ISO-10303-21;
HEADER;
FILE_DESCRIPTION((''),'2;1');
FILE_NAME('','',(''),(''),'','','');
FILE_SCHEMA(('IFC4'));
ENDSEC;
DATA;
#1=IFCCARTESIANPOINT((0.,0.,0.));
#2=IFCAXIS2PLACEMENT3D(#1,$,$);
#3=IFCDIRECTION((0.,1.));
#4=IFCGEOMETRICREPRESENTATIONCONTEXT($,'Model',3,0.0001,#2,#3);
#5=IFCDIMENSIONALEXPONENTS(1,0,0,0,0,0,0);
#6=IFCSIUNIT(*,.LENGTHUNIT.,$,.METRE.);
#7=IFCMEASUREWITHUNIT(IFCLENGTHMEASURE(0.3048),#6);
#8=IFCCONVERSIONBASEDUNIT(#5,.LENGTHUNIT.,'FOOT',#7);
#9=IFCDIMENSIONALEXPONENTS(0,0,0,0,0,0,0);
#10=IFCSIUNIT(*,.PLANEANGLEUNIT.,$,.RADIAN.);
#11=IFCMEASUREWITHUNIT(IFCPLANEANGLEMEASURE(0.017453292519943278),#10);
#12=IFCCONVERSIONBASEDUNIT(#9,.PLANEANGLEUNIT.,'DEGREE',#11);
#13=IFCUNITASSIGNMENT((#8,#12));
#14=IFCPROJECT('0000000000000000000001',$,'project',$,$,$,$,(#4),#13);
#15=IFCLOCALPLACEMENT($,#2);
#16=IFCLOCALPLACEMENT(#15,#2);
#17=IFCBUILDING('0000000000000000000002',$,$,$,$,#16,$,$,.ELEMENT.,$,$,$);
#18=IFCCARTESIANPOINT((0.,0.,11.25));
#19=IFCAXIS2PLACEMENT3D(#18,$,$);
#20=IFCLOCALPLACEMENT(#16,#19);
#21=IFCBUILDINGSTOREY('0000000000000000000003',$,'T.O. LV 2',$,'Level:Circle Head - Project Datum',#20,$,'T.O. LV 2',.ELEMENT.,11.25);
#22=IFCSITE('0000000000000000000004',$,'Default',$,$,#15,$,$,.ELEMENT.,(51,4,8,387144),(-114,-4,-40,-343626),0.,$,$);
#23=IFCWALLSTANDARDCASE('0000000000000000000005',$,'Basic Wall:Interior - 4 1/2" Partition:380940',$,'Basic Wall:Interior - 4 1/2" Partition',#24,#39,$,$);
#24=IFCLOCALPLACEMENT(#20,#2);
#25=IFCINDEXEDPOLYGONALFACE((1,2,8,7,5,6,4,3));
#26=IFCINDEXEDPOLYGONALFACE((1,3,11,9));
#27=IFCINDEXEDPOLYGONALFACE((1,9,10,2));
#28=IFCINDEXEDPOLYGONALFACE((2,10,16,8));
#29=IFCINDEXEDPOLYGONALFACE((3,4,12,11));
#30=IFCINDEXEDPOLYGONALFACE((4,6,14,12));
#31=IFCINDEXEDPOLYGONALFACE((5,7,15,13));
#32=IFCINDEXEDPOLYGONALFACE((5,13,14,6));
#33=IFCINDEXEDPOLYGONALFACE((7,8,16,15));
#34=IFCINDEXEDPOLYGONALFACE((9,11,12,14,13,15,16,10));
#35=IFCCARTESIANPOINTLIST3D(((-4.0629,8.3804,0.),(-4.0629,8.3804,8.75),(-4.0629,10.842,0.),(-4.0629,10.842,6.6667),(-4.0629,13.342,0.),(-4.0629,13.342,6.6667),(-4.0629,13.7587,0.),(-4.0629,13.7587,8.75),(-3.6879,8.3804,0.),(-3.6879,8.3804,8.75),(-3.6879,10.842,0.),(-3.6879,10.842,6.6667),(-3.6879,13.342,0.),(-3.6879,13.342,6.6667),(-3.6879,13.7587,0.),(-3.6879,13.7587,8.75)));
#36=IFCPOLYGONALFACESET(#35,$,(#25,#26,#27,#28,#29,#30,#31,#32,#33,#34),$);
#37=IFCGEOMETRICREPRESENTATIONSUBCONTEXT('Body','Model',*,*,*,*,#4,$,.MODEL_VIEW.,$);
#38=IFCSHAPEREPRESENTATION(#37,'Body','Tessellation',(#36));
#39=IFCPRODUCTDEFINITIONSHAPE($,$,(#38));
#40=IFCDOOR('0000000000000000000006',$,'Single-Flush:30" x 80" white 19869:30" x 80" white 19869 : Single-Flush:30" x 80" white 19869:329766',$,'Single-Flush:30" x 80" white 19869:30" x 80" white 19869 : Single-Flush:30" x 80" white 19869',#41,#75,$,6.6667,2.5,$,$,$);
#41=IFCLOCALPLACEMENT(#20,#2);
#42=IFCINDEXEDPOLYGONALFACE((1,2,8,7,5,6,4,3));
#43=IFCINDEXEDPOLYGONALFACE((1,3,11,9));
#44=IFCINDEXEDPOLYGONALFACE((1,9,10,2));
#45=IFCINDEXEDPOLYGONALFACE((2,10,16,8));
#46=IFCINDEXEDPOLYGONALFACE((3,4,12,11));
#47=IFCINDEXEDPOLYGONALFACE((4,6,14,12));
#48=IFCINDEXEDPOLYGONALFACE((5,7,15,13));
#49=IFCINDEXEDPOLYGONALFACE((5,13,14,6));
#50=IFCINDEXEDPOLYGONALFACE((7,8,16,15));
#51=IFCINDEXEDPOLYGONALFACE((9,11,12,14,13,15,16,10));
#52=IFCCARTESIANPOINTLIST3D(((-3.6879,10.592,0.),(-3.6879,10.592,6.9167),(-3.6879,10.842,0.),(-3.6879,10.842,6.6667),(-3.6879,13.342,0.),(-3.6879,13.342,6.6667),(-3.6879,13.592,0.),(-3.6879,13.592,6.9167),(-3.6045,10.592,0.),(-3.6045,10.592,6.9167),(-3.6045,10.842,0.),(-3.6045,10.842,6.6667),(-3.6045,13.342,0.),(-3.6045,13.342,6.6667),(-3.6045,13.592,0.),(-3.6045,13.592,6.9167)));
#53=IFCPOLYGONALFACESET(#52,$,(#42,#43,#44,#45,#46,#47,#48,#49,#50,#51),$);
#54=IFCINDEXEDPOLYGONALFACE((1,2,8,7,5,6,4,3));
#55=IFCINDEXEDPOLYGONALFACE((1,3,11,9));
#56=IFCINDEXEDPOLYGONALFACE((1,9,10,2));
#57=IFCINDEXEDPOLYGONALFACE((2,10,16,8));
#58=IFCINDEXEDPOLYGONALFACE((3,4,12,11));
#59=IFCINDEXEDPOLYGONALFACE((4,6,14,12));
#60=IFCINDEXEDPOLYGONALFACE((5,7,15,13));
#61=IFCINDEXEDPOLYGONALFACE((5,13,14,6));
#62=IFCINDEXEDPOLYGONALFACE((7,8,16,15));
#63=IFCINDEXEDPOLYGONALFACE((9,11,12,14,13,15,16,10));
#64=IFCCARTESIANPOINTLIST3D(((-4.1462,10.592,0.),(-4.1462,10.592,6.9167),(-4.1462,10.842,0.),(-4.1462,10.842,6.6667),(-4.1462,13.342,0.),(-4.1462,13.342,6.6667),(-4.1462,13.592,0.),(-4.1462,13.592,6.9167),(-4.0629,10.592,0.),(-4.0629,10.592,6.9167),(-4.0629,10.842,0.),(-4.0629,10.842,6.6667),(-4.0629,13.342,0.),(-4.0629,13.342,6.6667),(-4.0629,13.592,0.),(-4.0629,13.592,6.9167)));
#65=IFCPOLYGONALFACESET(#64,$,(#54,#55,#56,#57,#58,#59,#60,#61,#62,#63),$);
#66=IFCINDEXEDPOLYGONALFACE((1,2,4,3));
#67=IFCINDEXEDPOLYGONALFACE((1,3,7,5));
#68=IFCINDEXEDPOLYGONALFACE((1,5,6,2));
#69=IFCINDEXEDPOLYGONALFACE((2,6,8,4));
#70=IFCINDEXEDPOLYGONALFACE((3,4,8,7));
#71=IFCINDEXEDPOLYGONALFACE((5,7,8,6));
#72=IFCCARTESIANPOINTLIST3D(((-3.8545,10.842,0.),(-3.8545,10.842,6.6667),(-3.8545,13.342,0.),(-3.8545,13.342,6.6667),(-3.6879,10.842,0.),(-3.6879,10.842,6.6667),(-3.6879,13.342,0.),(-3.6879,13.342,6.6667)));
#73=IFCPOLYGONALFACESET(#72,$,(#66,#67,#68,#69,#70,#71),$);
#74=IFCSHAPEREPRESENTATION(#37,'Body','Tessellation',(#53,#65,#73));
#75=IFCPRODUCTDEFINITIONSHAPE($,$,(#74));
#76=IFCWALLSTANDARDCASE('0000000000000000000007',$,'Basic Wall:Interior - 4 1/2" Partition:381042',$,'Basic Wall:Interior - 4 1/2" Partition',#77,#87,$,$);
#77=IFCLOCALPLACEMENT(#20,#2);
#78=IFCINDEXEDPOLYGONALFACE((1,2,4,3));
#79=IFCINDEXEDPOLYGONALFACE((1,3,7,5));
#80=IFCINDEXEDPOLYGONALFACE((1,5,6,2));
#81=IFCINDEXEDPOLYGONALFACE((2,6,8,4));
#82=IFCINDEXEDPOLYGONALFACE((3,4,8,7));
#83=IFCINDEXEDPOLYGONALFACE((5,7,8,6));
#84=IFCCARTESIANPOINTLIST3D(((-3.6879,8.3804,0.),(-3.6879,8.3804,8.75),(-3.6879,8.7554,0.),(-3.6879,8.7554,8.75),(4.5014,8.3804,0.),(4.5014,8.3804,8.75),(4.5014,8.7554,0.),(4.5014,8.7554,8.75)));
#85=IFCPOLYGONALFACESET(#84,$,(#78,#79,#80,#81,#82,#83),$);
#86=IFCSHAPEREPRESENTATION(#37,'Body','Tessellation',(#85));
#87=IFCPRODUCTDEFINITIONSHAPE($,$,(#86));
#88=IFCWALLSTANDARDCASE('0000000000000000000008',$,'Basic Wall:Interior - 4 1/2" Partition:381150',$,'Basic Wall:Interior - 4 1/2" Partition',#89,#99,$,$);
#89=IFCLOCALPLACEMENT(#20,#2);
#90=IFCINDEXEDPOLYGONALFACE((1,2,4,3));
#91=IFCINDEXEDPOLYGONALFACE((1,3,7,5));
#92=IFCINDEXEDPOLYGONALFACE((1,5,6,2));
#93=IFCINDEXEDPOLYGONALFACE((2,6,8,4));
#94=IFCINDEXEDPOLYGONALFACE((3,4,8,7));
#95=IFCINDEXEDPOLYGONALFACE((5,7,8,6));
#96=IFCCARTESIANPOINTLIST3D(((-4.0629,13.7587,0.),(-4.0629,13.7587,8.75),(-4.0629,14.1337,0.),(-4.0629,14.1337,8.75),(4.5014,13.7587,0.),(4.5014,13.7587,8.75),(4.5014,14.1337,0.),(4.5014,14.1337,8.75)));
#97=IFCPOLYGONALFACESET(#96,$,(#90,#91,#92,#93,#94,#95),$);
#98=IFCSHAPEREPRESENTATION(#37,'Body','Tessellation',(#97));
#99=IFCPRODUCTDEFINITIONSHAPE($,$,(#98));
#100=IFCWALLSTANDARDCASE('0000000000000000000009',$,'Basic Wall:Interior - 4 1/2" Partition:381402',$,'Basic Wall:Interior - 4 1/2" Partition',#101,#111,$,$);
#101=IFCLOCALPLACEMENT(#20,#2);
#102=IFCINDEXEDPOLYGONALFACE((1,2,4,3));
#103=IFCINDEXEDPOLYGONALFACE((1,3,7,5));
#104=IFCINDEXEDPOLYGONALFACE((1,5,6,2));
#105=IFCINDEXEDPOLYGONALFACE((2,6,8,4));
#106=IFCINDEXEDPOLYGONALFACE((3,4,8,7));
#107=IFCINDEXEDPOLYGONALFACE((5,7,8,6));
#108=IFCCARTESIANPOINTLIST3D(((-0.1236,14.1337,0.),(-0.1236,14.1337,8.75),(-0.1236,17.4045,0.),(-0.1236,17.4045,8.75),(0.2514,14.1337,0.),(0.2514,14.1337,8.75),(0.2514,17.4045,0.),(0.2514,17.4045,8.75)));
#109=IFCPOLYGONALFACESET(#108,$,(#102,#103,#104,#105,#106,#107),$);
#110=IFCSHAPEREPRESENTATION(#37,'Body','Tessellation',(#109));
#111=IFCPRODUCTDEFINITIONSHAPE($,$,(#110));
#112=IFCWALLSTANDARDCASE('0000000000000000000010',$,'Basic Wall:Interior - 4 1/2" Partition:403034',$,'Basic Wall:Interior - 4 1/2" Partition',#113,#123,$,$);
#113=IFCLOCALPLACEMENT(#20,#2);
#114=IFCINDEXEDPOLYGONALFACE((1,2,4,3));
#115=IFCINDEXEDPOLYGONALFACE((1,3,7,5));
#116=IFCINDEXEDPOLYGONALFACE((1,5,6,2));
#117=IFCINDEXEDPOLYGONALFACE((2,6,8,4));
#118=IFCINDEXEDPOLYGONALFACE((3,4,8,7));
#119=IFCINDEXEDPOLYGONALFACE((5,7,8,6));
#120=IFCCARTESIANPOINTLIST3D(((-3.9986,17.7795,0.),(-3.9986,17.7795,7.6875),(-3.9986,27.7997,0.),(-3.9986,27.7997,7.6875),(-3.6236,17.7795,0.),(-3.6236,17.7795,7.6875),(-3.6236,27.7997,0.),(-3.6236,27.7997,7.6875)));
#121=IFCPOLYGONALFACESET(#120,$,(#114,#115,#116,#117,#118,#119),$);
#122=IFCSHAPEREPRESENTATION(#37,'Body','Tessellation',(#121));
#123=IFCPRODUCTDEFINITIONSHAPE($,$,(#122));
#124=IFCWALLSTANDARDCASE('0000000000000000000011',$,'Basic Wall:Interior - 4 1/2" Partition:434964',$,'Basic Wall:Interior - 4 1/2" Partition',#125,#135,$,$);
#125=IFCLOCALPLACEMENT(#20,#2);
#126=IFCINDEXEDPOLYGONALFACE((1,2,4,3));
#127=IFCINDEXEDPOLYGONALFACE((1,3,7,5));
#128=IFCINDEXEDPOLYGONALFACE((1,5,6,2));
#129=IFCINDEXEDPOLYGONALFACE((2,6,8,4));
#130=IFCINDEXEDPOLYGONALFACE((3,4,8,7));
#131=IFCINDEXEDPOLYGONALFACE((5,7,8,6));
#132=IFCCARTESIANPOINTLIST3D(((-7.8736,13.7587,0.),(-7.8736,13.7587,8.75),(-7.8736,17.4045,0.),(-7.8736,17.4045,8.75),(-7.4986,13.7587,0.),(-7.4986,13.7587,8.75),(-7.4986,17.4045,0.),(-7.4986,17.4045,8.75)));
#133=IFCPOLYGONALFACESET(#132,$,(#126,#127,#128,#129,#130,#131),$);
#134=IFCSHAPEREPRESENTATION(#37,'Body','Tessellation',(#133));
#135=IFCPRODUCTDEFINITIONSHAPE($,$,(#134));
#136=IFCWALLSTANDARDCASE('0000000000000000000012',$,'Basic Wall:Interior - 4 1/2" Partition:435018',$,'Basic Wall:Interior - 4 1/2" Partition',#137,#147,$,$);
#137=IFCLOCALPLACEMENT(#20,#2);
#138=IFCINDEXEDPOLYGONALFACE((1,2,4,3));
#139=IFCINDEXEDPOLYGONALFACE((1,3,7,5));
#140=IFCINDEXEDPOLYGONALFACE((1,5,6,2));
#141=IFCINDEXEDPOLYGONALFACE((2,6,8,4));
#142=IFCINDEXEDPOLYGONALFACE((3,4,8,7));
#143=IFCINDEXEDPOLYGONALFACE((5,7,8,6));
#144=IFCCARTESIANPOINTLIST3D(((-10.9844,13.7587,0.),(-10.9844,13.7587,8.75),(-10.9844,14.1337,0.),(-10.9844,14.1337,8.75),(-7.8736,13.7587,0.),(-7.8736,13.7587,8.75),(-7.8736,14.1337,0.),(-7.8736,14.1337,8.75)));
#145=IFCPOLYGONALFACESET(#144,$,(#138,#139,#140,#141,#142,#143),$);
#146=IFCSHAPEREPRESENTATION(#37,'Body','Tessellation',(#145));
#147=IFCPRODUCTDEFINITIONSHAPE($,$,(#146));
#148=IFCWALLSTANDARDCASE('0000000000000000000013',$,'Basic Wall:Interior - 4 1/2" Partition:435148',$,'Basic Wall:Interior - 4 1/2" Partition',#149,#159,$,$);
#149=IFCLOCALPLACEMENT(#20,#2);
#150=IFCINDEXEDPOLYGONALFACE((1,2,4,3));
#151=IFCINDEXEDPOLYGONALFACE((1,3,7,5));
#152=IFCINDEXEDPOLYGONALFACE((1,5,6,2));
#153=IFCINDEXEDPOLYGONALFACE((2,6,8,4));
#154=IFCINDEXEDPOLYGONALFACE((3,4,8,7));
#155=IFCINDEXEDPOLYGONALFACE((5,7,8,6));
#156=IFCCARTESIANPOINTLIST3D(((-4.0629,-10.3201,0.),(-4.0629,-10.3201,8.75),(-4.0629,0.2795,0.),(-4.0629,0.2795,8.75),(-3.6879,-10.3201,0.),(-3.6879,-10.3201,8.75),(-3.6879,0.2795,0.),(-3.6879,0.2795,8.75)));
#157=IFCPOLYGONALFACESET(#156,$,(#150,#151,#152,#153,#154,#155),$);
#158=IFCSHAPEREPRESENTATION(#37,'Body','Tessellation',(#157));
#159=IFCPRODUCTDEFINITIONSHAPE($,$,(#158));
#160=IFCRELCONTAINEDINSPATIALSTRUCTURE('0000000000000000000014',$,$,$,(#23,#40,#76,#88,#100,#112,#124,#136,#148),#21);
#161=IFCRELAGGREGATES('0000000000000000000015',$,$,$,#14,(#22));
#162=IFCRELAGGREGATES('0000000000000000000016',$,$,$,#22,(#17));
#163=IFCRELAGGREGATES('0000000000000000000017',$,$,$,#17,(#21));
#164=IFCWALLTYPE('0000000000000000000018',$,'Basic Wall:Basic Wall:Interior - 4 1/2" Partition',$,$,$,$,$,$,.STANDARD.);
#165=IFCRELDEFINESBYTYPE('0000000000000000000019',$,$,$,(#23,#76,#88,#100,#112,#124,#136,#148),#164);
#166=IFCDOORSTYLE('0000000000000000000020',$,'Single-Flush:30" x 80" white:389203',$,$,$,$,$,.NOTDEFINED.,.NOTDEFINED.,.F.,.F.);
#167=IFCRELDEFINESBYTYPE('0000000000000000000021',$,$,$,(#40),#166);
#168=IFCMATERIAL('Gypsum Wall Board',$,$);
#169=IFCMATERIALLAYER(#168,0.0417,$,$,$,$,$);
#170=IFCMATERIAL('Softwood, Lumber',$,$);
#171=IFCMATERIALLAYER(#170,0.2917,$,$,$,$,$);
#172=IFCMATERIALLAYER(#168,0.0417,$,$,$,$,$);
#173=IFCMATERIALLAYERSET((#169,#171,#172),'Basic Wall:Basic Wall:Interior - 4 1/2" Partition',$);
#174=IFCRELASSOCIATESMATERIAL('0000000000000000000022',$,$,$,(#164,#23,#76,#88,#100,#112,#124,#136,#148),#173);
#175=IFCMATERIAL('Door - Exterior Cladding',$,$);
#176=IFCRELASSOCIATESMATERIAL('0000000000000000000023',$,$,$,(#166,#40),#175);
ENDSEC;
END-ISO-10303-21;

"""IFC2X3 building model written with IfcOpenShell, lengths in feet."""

from ifc_helpers import new_model, entity, si_unit, converted_unit, direction, frame, frame_2d, origin, place, context, subcontext, project, spatial, polyline, rectangle, outline, extrude, source, transform, mapped, material, layer, layer_set, layer_usage, type_object, type_shapes, element, fill, save


model = new_model("IFC2X3")

# Units and contexts
model_context = context("Model", 3, precision=0.0001, world=origin(), true_north=direction((0.0, 1.0)))
body_context = subcontext(model_context, "Body", "Model", "MODEL_VIEW")
ifc_project = project(units=[converted_unit("LENGTHUNIT", "FOOT", entity("IfcLengthMeasure", 0.3048), si_unit("LENGTHUNIT", "METRE"), dimensions=[1, 0, 0, 0, 0, 0, 0]), converted_unit("PLANEANGLEUNIT", "DEGREE", entity("IfcPlaneAngleMeasure", 0.017453292519943278), si_unit("PLANEANGLEUNIT", "RADIAN"), dimensions=[0, 0, 0, 0, 0, 0, 0])], contexts=[model_context])

# Site, building, storey
site_placement = place(None, origin())
site = spatial("IfcSite", under=ifc_project, at=site_placement, Name="Default", CompositionType="ELEMENT", RefLatitude=(51, 4, 8, 387144), RefLongitude=(-114, -4, -40, -343626), RefElevation=0.0)
building_placement = place(site_placement, origin())
building = spatial("IfcBuilding", under=site, at=building_placement, CompositionType="ELEMENT")
storey_placement = place(building_placement, frame((0.0, 0.0, 11.25)))
storey = spatial("IfcBuildingStorey", under=building, at=storey_placement, Name="T.O. LV 2", ObjectType="Level:Circle Head - Project Datum", LongName="T.O. LV 2", CompositionType="ELEMENT", Elevation=11.25)

# Shared definitions
ifc_material_1 = material(Name="Gypsum Wall Board")
ifc_layer_1 = layer(ifc_material_1, 0.0417)
ifc_material_2 = material(Name="Softwood, Lumber")
ifc_layer_2 = layer(ifc_material_2, 0.2917)
ifc_layer_3 = layer(ifc_material_1, 0.0417)
ifc_layer_set_1 = layer_set([ifc_layer_1, ifc_layer_2, ifc_layer_3], Name="Basic Wall:Basic Wall:Interior - 4 1/2\" Partition")
wall_type_1 = type_object("IfcWallType", Name="Basic Wall:Basic Wall:Interior - 4 1/2\" Partition", PredefinedType="STANDARD", material=ifc_layer_set_1)

# Wall, opening, door
ifc_layer_usage_1 = layer_usage(ifc_layer_set_1, "AXIS2", "NEGATIVE", 0.1875)
wall_1_placement = place(storey_placement, frame((-3.8754, 13.7587, 0.0), z_axis=(0.0, 0.0, 1.0), x_axis=(0.0, -1.0, 0.0)))
wall_1 = element("IfcWallStandardCase", 1, at=wall_1_placement, inside=storey, type_object=wall_type_1, material=ifc_layer_usage_1, Name="Basic Wall:Interior - 4 1/2\" Partition:380940", ObjectType="Basic Wall:Interior - 4 1/2\" Partition", context=body_context, shape_type="SweptSolid", body=[
    extrude(rectangle(XDim=5.3783, YDim=0.375, at=frame_2d((2.6891, 0.0), x_axis=(1.0, 0.0))), origin(), (0.0, 0.0, 1.0), 8.75),
])
opening_1_placement = place(wall_1_placement, frame((13.7587, 3.8754, 0.0), z_axis=(0.0, 0.0, 1.0), x_axis=(0.0, 1.0, 0.0)))
opening_1 = element("IfcOpeningElement", 2, at=opening_1_placement, cuts=wall_1, ObjectType="Opening", context=body_context, shape_type="SweptSolid", body=[
    extrude(rectangle(XDim=6.6667, YDim=2.5, at=frame_2d((0.0, 0.0), x_axis=(1.0, 0.0))), frame((-4.0666, 12.092, 3.3333), z_axis=(1.0, 0.0, 0.0), x_axis=(0.0, 0.0, 1.0)), (0.0, 0.0, 1.0), 0.3825),
])
ifc_material_3 = material(Name="Door - Exterior Cladding")
door_style_1 = type_object("IfcDoorStyle", Name="Single-Flush:30\" x 80\" white:389203", ConstructionType="NOTDEFINED", OperationType="NOTDEFINED", ParameterTakesPrecedence=False, Sizeable=False, material=ifc_material_3)
shared_shape_1 = source(origin(), body_context, "Body", "SweptSolid", [
    extrude(outline(polyline([(-1.5, -3.5208), (1.5, -3.5208), (1.5, 3.3958), (1.25, 3.3958), (1.25, -3.2708), (-1.25, -3.2708), (-1.25, 3.3958), (-1.5, 3.3958), (-1.5, -3.5208)])), frame((1.25, -0.0038, 3.3958), z_axis=(0.0, 1.0, 0.0), x_axis=(1.0, 0.0, 0.0)), (0.0, 0.0, 1.0), 0.0833),
    extrude(outline(polyline([(-3.3958, -1.5), (3.5208, -1.5), (3.5208, 1.5), (-3.3958, 1.5), (-3.3958, 1.25), (3.2708, 1.25), (3.2708, -1.25), (-3.3958, -1.25), (-3.3958, -1.5)])), frame((1.25, -0.4621, 3.3958), z_axis=(0.0, 1.0, 0.0), x_axis=(0.0, 0.0, 1.0)), (0.0, 0.0, 1.0), 0.0833),
    extrude(rectangle(XDim=0.1667, YDim=2.5, at=frame_2d((0.0, 0.0), x_axis=(1.0, 0.0))), frame((1.25, -0.0871, 0.0), z_axis=(0.0, 0.0, 1.0), x_axis=(0.0, 1.0, 0.0)), (0.0, 0.0, 1.0), 6.6667),
])
type_shapes(door_style_1, [shared_shape_1])
door_1_placement = place(opening_1_placement, frame((-3.6841, 13.342, 0.0), z_axis=(0.0, 0.0, 1.0), x_axis=(0.0, -1.0, 0.0)))
door_1 = element("IfcDoor", 3, at=door_1_placement, inside=storey, type_object=door_style_1, material=ifc_material_3, Name="Single-Flush:30\" x 80\" white 19869:30\" x 80\" white 19869 : Single-Flush:30\" x 80\" white 19869:329766", ObjectType="Single-Flush:30\" x 80\" white 19869:30\" x 80\" white 19869 : Single-Flush:30\" x 80\" white 19869", OverallHeight=6.6667, OverallWidth=2.5, context=body_context, shape_type="MappedRepresentation", body=[
    mapped(shared_shape_1, transform((0.0, 0.0, 0.0), scale=1.0)),
])
fill(opening_1, door_1)

# Walls
ifc_layer_usage_2 = layer_usage(ifc_layer_set_1, "AXIS2", "NEGATIVE", 0.1875)
wall_2_placement = place(storey_placement, frame((-3.6879, 8.5679, 0.0)))
element("IfcWallStandardCase", 4, at=wall_2_placement, inside=storey, type_object=wall_type_1, material=ifc_layer_usage_2, Name="Basic Wall:Interior - 4 1/2\" Partition:381042", ObjectType="Basic Wall:Interior - 4 1/2\" Partition", context=body_context, shape_type="SweptSolid", body=[
    extrude(rectangle(XDim=8.1893, YDim=0.375, at=frame_2d((4.0947, 0.0), x_axis=(-1.0, 0.0))), origin(), (0.0, 0.0, 1.0), 8.75),
])
ifc_layer_usage_3 = layer_usage(ifc_layer_set_1, "AXIS2", "NEGATIVE", 0.1875)
wall_3_placement = place(storey_placement, frame((-4.0629, 13.9462, 0.0)))
element("IfcWallStandardCase", 5, at=wall_3_placement, inside=storey, type_object=wall_type_1, material=ifc_layer_usage_3, Name="Basic Wall:Interior - 4 1/2\" Partition:381150", ObjectType="Basic Wall:Interior - 4 1/2\" Partition", context=body_context, shape_type="SweptSolid", body=[
    extrude(rectangle(XDim=8.5643, YDim=0.375, at=frame_2d((4.2822, 0.0), x_axis=(-1.0, 0.0))), origin(), (0.0, 0.0, 1.0), 8.75),
])
ifc_layer_usage_4 = layer_usage(ifc_layer_set_1, "AXIS2", "NEGATIVE", 0.1875)
wall_4_placement = place(storey_placement, frame((0.0639, 17.4045, 0.0), z_axis=(0.0, 0.0, 1.0), x_axis=(0.0, -1.0, 0.0)))
element("IfcWallStandardCase", 6, at=wall_4_placement, inside=storey, type_object=wall_type_1, material=ifc_layer_usage_4, Name="Basic Wall:Interior - 4 1/2\" Partition:381402", ObjectType="Basic Wall:Interior - 4 1/2\" Partition", context=body_context, shape_type="SweptSolid", body=[
    extrude(rectangle(XDim=3.2708, YDim=0.375, at=frame_2d((1.6354, 0.0), x_axis=(-1.0, 0.0))), origin(), (0.0, 0.0, 1.0), 8.75),
])
ifc_layer_usage_5 = layer_usage(ifc_layer_set_1, "AXIS2", "NEGATIVE", 0.1875)
wall_5_placement = place(storey_placement, frame((-3.8111, 27.7997, 0.0), z_axis=(0.0, 0.0, 1.0), x_axis=(0.0, -1.0, 0.0)))
element("IfcWallStandardCase", 7, at=wall_5_placement, inside=storey, type_object=wall_type_1, material=ifc_layer_usage_5, Name="Basic Wall:Interior - 4 1/2\" Partition:403034", ObjectType="Basic Wall:Interior - 4 1/2\" Partition", context=body_context, shape_type="SweptSolid", body=[
    extrude(rectangle(XDim=10.0202, YDim=0.375, at=frame_2d((5.0101, 0.0), x_axis=(-1.0, 0.0))), origin(), (0.0, 0.0, 1.0), 7.6875),
])
ifc_layer_usage_6 = layer_usage(ifc_layer_set_1, "AXIS2", "NEGATIVE", 0.1875)
wall_6_placement = place(storey_placement, frame((-7.6861, 17.4045, 0.0), z_axis=(0.0, 0.0, 1.0), x_axis=(0.0, -1.0, 0.0)))
element("IfcWallStandardCase", 8, at=wall_6_placement, inside=storey, type_object=wall_type_1, material=ifc_layer_usage_6, Name="Basic Wall:Interior - 4 1/2\" Partition:434964", ObjectType="Basic Wall:Interior - 4 1/2\" Partition", context=body_context, shape_type="SweptSolid", body=[
    extrude(rectangle(XDim=3.6458, YDim=0.375, at=frame_2d((1.8229, 0.0), x_axis=(-1.0, 0.0))), origin(), (0.0, 0.0, 1.0), 8.75),
])
ifc_layer_usage_7 = layer_usage(ifc_layer_set_1, "AXIS2", "NEGATIVE", 0.1875)
wall_7_placement = place(storey_placement, frame((-7.8736, 13.9462, 0.0), z_axis=(0.0, 0.0, 1.0), x_axis=(-1.0, 0.0, 0.0)))
element("IfcWallStandardCase", 9, at=wall_7_placement, inside=storey, type_object=wall_type_1, material=ifc_layer_usage_7, Name="Basic Wall:Interior - 4 1/2\" Partition:435018", ObjectType="Basic Wall:Interior - 4 1/2\" Partition", context=body_context, shape_type="SweptSolid", body=[
    extrude(rectangle(XDim=3.1108, YDim=0.375, at=frame_2d((1.5554, 0.0), x_axis=(-1.0, 0.0))), origin(), (0.0, 0.0, 1.0), 8.75),
])
ifc_layer_usage_8 = layer_usage(ifc_layer_set_1, "AXIS2", "NEGATIVE", 0.1875)
wall_8_placement = place(storey_placement, frame((-3.8754, 0.2795, 0.0), z_axis=(0.0, 0.0, 1.0), x_axis=(0.0, -1.0, 0.0)))
element("IfcWallStandardCase", 10, at=wall_8_placement, inside=storey, type_object=wall_type_1, material=ifc_layer_usage_8, Name="Basic Wall:Interior - 4 1/2\" Partition:435148", ObjectType="Basic Wall:Interior - 4 1/2\" Partition", context=body_context, shape_type="SweptSolid", body=[
    extrude(rectangle(XDim=10.5996, YDim=0.375, at=frame_2d((5.2998, 0.0), x_axis=(-1.0, 0.0))), origin(), (0.0, 0.0, 1.0), 8.75),
])

save(model, "model.ifc")
